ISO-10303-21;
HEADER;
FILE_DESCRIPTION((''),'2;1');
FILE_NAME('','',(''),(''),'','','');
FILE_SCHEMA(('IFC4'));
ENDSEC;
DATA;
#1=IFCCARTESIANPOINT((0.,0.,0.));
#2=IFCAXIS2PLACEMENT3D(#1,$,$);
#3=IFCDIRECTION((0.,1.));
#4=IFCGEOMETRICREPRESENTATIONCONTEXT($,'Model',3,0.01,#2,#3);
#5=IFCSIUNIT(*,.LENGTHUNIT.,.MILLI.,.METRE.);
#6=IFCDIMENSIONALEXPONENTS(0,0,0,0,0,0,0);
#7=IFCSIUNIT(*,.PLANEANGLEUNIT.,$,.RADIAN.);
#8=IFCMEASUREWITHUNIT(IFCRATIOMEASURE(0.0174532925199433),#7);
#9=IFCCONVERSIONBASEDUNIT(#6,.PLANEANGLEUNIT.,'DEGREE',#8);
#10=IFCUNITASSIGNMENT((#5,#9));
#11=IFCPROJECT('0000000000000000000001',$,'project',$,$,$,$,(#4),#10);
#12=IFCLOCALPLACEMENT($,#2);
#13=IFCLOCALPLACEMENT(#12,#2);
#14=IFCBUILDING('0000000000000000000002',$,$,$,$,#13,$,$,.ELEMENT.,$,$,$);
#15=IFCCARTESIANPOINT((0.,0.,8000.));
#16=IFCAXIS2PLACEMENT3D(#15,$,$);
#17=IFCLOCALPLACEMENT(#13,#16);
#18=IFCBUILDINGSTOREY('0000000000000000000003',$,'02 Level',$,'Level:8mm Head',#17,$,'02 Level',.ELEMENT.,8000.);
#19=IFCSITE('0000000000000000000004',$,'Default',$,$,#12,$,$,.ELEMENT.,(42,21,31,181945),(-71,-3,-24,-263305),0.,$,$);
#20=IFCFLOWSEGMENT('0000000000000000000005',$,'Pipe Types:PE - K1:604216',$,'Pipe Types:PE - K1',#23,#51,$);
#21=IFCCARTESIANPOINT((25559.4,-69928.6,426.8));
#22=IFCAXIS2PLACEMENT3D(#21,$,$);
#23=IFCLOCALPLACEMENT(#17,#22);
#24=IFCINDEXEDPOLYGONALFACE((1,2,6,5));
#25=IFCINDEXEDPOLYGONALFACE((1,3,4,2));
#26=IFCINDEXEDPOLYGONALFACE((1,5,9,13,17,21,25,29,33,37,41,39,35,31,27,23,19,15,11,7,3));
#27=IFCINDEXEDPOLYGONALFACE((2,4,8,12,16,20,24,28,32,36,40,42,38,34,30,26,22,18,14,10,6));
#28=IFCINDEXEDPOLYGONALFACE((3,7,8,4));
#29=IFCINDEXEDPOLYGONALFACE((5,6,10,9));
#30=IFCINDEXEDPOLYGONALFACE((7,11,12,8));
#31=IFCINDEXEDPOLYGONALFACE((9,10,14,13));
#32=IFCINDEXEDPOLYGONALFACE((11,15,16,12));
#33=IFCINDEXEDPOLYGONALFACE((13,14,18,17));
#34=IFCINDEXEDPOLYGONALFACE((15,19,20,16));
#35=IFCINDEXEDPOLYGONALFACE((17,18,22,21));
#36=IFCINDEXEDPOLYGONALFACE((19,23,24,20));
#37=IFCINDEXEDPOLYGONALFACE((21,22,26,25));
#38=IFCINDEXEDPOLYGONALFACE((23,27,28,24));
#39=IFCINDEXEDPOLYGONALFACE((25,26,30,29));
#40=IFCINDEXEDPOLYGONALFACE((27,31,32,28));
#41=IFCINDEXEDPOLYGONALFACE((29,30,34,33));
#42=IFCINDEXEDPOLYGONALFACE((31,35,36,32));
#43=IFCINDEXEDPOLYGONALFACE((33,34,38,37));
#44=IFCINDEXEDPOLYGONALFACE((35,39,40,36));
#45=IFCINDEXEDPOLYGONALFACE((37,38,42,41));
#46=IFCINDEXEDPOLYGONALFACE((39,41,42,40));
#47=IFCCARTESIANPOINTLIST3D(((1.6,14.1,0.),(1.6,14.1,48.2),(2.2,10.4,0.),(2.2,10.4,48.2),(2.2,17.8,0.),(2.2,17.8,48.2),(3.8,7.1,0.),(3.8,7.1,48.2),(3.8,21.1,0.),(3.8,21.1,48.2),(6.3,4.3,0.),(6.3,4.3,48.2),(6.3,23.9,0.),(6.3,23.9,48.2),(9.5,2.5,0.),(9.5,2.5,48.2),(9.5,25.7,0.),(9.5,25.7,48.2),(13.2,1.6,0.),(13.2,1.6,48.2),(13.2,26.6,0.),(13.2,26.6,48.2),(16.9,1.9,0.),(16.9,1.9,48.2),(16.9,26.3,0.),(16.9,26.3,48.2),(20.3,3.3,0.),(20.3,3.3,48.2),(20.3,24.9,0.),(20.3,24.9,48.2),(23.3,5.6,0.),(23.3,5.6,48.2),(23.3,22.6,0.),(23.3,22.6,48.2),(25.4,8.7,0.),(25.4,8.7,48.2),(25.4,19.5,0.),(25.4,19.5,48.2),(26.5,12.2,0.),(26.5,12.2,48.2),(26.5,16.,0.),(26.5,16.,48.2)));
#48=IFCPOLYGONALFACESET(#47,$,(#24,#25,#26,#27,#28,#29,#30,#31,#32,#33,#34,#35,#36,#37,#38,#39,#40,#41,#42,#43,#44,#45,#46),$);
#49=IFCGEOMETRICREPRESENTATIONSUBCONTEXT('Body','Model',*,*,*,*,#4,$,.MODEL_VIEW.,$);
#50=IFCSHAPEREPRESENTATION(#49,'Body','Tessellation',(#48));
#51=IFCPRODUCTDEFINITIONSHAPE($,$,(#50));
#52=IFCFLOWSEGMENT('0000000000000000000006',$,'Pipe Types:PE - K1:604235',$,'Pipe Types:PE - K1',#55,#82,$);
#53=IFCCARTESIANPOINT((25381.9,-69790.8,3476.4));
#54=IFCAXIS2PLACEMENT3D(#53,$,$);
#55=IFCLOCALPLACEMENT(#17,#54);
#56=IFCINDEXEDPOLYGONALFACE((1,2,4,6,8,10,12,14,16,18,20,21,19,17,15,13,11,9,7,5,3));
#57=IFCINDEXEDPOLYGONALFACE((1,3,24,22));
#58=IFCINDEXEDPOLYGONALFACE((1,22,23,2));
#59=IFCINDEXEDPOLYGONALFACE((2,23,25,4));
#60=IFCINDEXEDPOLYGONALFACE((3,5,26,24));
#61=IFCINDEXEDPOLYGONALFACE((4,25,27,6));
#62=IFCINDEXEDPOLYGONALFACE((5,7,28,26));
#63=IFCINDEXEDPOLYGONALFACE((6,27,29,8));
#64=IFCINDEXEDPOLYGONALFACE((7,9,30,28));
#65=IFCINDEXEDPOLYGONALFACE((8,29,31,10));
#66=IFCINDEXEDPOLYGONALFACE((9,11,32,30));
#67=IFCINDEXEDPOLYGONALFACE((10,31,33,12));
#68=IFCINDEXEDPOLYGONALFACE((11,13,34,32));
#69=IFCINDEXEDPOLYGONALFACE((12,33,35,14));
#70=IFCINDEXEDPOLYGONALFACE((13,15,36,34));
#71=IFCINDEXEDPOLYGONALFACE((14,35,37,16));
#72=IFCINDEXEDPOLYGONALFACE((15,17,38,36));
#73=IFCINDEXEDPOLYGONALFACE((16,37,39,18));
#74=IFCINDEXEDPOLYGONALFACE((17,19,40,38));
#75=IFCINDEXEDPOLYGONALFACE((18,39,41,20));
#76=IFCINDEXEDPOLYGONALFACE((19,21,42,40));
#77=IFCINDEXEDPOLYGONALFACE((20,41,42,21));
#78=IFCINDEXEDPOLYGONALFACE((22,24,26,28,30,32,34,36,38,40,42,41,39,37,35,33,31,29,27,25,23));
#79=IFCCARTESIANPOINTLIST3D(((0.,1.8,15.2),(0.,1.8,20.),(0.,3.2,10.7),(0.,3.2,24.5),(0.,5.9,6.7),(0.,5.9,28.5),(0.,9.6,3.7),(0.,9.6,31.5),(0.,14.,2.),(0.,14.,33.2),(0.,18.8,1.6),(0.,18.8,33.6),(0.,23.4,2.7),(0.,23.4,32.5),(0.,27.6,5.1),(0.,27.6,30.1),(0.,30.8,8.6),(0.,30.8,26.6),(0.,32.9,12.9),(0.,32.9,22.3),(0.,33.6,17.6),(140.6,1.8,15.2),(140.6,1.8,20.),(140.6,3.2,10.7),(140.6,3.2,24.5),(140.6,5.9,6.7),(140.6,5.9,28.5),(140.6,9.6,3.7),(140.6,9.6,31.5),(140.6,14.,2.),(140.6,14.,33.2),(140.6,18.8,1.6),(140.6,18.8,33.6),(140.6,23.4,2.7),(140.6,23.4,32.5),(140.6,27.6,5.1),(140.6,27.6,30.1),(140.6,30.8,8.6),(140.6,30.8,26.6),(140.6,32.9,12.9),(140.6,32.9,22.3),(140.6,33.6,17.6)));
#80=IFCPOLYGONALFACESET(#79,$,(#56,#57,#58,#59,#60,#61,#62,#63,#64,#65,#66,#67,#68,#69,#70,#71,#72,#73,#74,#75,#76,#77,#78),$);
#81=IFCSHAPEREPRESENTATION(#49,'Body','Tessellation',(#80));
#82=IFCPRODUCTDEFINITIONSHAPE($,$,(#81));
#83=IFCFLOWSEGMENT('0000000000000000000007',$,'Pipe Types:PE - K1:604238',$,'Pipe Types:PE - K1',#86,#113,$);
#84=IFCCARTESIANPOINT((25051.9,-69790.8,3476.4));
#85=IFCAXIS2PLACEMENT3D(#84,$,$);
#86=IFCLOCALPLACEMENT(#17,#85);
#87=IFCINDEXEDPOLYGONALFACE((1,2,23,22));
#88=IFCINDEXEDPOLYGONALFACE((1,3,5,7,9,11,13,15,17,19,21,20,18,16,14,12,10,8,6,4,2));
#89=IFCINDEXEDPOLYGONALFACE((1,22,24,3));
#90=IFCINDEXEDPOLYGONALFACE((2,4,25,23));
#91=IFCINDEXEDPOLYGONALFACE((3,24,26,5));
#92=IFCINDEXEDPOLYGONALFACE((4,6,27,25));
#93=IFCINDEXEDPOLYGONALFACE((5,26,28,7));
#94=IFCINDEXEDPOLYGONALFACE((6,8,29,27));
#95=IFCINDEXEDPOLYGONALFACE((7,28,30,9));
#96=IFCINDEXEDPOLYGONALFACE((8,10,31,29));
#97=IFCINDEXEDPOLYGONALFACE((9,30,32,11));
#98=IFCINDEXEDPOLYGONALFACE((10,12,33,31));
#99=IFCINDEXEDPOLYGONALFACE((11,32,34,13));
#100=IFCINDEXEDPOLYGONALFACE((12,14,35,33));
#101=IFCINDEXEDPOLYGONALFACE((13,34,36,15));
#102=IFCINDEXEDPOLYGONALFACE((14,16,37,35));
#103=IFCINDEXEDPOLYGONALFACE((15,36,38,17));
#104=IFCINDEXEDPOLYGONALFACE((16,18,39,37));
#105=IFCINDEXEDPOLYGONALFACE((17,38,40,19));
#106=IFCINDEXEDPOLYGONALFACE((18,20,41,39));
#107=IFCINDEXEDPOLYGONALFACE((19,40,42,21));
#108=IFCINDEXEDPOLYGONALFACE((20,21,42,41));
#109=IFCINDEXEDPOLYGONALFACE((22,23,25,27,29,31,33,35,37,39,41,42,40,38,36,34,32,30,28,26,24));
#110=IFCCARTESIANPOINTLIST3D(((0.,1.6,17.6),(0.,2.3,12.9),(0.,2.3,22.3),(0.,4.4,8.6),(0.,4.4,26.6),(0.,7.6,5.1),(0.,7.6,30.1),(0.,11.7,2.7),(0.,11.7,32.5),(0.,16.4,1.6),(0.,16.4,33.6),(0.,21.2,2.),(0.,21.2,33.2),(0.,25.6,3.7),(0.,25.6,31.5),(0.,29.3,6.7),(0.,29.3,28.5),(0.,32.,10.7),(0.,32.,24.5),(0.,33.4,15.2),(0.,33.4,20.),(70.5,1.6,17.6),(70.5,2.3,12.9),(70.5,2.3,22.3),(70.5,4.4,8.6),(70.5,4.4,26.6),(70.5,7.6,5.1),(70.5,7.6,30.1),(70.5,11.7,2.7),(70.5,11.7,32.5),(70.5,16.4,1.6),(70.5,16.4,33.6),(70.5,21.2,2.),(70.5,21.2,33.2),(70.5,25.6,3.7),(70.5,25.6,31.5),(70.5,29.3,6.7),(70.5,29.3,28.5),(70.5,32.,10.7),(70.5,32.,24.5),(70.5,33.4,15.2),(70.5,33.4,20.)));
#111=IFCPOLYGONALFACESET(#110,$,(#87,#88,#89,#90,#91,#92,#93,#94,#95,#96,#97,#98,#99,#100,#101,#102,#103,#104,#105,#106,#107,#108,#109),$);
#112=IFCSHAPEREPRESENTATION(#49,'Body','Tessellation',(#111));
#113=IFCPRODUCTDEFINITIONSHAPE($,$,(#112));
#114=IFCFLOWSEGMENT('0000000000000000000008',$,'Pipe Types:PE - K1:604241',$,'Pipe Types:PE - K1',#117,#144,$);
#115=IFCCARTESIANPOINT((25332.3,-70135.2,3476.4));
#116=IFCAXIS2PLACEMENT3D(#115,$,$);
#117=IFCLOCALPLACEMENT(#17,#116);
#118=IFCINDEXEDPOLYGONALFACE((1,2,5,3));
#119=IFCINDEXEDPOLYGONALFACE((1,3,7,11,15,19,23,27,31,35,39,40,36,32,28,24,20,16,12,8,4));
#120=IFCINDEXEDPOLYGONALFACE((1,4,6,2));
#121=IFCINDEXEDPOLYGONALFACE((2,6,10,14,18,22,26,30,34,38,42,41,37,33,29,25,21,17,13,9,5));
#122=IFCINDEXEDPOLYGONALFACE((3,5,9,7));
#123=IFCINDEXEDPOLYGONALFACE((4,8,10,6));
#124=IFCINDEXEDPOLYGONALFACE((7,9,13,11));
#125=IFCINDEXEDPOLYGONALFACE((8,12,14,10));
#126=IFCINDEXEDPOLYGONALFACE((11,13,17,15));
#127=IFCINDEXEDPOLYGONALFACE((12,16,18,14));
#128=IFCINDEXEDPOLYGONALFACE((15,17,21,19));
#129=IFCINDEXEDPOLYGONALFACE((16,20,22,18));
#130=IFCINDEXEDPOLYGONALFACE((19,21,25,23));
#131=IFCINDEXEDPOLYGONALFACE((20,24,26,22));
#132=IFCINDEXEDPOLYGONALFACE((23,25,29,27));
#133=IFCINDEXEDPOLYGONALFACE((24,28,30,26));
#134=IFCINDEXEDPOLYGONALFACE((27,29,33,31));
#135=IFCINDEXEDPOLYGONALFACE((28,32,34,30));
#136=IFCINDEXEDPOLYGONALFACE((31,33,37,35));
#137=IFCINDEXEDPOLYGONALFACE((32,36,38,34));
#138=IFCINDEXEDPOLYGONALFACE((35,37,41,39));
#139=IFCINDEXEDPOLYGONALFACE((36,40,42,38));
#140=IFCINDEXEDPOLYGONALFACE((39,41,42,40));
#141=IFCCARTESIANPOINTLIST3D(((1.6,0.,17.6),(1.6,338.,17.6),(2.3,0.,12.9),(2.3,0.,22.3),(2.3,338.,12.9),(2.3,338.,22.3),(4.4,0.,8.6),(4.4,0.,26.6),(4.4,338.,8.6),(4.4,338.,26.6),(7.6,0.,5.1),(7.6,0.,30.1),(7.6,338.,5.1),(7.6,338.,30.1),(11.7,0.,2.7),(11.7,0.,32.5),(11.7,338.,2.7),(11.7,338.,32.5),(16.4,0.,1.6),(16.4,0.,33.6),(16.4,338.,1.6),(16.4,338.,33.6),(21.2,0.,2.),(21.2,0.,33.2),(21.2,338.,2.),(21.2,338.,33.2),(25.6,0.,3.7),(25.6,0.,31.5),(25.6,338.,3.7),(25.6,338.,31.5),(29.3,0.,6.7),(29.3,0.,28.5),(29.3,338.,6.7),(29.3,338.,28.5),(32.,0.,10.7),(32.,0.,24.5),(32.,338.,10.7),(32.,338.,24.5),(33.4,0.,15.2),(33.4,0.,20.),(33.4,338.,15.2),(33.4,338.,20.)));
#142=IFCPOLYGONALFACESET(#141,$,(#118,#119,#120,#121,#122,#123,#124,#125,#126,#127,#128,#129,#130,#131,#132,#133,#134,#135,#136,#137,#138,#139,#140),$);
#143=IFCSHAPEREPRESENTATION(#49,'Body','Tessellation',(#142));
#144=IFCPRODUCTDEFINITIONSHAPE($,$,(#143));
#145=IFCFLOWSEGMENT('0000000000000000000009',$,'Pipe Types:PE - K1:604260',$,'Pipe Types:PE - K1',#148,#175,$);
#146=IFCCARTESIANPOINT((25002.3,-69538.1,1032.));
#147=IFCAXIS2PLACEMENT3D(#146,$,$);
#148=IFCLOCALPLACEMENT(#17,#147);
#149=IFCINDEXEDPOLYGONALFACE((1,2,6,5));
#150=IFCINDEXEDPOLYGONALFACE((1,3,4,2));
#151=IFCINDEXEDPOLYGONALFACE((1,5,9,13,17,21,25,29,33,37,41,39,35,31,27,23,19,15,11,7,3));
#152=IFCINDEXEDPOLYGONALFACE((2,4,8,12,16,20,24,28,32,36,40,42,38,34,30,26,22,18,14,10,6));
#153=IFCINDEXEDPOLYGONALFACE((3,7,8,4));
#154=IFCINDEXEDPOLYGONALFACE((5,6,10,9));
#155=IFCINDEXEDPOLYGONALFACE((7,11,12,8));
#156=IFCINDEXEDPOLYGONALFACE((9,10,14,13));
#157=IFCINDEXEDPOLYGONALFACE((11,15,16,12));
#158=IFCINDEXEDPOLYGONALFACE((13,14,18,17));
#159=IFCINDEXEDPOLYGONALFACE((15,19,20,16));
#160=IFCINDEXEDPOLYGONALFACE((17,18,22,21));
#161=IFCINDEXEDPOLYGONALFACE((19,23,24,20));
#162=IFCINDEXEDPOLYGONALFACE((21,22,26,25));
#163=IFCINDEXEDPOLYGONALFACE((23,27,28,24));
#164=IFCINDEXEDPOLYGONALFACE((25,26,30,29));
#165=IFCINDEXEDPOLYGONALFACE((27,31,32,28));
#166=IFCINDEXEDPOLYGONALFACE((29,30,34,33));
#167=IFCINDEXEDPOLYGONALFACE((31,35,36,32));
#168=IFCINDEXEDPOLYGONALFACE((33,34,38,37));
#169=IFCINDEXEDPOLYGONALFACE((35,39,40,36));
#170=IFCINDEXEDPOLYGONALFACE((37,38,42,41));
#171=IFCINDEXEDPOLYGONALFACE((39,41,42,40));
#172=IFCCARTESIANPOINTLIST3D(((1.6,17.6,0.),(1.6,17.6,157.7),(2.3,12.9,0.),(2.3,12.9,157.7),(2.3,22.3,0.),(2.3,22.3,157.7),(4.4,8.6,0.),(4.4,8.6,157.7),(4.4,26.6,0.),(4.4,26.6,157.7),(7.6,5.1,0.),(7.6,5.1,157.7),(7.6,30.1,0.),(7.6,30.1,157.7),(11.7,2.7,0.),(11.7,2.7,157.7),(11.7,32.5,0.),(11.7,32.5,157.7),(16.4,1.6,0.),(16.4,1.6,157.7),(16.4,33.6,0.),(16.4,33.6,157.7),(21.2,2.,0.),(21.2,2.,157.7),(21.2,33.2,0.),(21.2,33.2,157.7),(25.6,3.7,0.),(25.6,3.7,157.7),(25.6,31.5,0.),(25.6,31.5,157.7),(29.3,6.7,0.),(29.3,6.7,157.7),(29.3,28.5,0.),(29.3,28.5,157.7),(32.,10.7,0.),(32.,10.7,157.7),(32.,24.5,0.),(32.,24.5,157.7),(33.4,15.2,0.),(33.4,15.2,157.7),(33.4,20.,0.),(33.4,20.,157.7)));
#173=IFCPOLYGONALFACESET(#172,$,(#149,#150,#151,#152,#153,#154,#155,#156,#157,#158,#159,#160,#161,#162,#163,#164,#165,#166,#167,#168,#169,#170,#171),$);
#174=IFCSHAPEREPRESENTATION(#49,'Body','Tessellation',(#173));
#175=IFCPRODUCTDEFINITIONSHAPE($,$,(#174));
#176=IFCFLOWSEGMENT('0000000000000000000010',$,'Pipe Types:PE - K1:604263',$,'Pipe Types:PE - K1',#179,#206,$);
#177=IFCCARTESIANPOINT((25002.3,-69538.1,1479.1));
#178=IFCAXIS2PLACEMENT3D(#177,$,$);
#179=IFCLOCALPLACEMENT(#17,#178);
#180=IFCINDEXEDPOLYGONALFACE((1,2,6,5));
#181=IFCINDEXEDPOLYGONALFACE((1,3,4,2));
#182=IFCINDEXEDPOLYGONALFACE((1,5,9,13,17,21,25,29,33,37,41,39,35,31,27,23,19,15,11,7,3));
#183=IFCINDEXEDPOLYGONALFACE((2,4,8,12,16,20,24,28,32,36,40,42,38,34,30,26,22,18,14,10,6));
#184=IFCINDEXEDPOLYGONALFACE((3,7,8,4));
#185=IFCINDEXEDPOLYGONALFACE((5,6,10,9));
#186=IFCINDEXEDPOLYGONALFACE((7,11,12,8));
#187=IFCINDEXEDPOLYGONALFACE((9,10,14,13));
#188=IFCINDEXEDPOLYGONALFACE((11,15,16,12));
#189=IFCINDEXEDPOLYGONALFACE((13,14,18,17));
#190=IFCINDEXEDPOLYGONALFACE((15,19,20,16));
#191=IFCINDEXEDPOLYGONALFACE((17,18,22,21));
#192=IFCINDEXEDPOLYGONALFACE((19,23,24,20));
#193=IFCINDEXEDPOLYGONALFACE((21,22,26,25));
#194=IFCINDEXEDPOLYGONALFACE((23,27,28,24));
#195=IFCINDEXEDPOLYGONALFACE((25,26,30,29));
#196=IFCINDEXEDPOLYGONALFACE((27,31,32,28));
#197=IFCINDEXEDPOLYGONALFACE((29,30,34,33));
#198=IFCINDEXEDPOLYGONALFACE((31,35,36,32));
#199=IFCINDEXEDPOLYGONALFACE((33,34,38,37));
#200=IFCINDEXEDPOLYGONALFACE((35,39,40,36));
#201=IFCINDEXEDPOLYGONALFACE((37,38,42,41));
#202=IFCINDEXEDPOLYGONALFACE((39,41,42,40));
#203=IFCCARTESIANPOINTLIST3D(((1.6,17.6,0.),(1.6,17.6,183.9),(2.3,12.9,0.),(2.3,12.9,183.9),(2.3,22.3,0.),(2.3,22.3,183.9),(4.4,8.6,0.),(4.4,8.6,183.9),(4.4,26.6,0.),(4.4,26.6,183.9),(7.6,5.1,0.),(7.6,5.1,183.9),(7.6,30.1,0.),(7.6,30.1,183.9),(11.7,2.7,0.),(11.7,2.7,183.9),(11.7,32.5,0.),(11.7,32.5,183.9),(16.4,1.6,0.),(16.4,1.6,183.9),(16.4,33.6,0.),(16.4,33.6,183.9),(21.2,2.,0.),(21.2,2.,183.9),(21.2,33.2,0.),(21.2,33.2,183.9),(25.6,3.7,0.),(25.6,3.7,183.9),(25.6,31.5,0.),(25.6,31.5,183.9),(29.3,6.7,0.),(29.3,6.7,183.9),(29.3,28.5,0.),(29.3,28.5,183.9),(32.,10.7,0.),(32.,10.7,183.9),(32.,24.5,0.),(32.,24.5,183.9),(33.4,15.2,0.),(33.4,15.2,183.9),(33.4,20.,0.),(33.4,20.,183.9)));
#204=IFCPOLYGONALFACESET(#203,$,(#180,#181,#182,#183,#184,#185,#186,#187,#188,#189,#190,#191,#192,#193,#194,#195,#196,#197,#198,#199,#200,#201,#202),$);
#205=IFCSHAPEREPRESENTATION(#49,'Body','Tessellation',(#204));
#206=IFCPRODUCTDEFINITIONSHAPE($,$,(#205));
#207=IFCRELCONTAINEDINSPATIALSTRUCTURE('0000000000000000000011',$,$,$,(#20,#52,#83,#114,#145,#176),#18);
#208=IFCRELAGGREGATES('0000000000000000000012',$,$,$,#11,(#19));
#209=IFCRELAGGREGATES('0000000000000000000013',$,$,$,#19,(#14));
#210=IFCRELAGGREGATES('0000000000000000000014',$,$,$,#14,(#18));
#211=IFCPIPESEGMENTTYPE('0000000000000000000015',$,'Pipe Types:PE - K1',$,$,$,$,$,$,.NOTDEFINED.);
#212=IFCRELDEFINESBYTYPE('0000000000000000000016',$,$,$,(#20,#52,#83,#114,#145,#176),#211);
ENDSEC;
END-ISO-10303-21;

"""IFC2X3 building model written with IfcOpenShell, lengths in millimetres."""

from ifc_helpers import new_model, entity, si_unit, converted_unit, direction, frame, frame_2d, origin, origin_2d_with_axis, place, context, subcontext, project, spatial, circle, extrude, type_object, element, save


model = new_model("IFC2X3")

# Units and contexts
model_context = context("Model", 3, precision=0.01, world=origin(), true_north=direction((0.0, 1.0)))
body_context = subcontext(model_context, "Body", "Model", "MODEL_VIEW")
ifc_project = project(units=[si_unit("LENGTHUNIT", "METRE", prefix="MILLI"), converted_unit("PLANEANGLEUNIT", "DEGREE", entity("IfcRatioMeasure", 0.0174532925199433), si_unit("PLANEANGLEUNIT", "RADIAN"), dimensions=[0, 0, 0, 0, 0, 0, 0])], contexts=[model_context])

# Site, building, storey
site_placement = place(None, origin())
site = spatial("IfcSite", under=ifc_project, at=site_placement, Name="Default", CompositionType="ELEMENT", RefLatitude=(42, 21, 31, 181945), RefLongitude=(-71, -3, -24, -263305), RefElevation=0.0)
building_placement = place(site_placement, origin())
building = spatial("IfcBuilding", under=site, at=building_placement, CompositionType="ELEMENT")
storey_placement = place(building_placement, frame((0.0, 0.0, 8000.0)))
storey = spatial("IfcBuildingStorey", under=building, at=storey_placement, Name="02 Level", ObjectType="Level:8mm Head", LongName="02 Level", CompositionType="ELEMENT", Elevation=8000.0)

# Flow segments
pipe_segment_type = type_object("IfcPipeSegmentType", Name="Pipe Types:PE - K1", PredefinedType="NOTDEFINED")
flow_segment_1_placement = place(storey_placement, frame((25559.4, -69928.6, 426.8)))
element("IfcFlowSegment", 1, at=flow_segment_1_placement, inside=storey, type_object=pipe_segment_type, Name="Pipe Types:PE - K1:604216", ObjectType="Pipe Types:PE - K1", context=body_context, shape_type="SweptSolid", body=[
    extrude(circle(Radius=12.5, at=frame_2d((0.0, 0.0), x_axis=(1.0, 0.0))), frame((14.1, 14.1, 0.0), z_axis=(0.0, 0.0, 1.0), x_axis=(-1.0, 0.0, 0.0)), (0.0, 0.0, 1.0), 48.2),
])
flow_segment_2_placement = place(storey_placement, frame((25381.9, -69790.8, 3476.4)))
element("IfcFlowSegment", 2, at=flow_segment_2_placement, inside=storey, type_object=pipe_segment_type, Name="Pipe Types:PE - K1:604235", ObjectType="Pipe Types:PE - K1", context=body_context, shape_type="SweptSolid", body=[
    extrude(circle(Radius=16.0, at=origin_2d_with_axis()), frame((0.0, 17.6, 17.6), z_axis=(1.0, 0.0, 0.0), x_axis=(0.0, 1.0, 0.0)), (0.0, 0.0, 1.0), 140.6),
])
flow_segment_3_placement = place(storey_placement, frame((25051.9, -69790.8, 3476.4)))
element("IfcFlowSegment", 3, at=flow_segment_3_placement, inside=storey, type_object=pipe_segment_type, Name="Pipe Types:PE - K1:604238", ObjectType="Pipe Types:PE - K1", context=body_context, shape_type="SweptSolid", body=[
    extrude(circle(Radius=16.0, at=origin_2d_with_axis()), frame((0.0, 17.6, 17.6), z_axis=(1.0, 0.0, 0.0), x_axis=(0.0, -1.0, 0.0)), (0.0, 0.0, 1.0), 70.5),
])
flow_segment_4_placement = place(storey_placement, frame((25332.3, -70135.2, 3476.4)))
element("IfcFlowSegment", 4, at=flow_segment_4_placement, inside=storey, type_object=pipe_segment_type, Name="Pipe Types:PE - K1:604241", ObjectType="Pipe Types:PE - K1", context=body_context, shape_type="SweptSolid", body=[
    extrude(circle(Radius=16.0, at=origin_2d_with_axis()), frame((17.6, 0.0, 17.6), z_axis=(0.0, 1.0, 0.0), x_axis=(-1.0, 0.0, 0.0)), (0.0, 0.0, 1.0), 338.0),
])
flow_segment_5_placement = place(storey_placement, frame((25002.3, -69538.1, 1032.0)))
element("IfcFlowSegment", 5, at=flow_segment_5_placement, inside=storey, type_object=pipe_segment_type, Name="Pipe Types:PE - K1:604260", ObjectType="Pipe Types:PE - K1", context=body_context, shape_type="SweptSolid", body=[
    extrude(circle(Radius=16.0, at=origin_2d_with_axis()), frame((17.6, 17.6, 0.0), z_axis=(0.0, 0.0, 1.0), x_axis=(-1.0, 0.0, 0.0)), (0.0, 0.0, 1.0), 157.7),
])
flow_segment_6_placement = place(storey_placement, frame((25002.3, -69538.1, 1479.1)))
element("IfcFlowSegment", 6, at=flow_segment_6_placement, inside=storey, type_object=pipe_segment_type, Name="Pipe Types:PE - K1:604263", ObjectType="Pipe Types:PE - K1", context=body_context, shape_type="SweptSolid", body=[
    extrude(circle(Radius=16.0, at=origin_2d_with_axis()), frame((17.6, 17.6, 0.0), z_axis=(0.0, 0.0, 1.0), x_axis=(-1.0, 0.0, 0.0)), (0.0, 0.0, 1.0), 183.9),
])

save(model, "model.ifc")
